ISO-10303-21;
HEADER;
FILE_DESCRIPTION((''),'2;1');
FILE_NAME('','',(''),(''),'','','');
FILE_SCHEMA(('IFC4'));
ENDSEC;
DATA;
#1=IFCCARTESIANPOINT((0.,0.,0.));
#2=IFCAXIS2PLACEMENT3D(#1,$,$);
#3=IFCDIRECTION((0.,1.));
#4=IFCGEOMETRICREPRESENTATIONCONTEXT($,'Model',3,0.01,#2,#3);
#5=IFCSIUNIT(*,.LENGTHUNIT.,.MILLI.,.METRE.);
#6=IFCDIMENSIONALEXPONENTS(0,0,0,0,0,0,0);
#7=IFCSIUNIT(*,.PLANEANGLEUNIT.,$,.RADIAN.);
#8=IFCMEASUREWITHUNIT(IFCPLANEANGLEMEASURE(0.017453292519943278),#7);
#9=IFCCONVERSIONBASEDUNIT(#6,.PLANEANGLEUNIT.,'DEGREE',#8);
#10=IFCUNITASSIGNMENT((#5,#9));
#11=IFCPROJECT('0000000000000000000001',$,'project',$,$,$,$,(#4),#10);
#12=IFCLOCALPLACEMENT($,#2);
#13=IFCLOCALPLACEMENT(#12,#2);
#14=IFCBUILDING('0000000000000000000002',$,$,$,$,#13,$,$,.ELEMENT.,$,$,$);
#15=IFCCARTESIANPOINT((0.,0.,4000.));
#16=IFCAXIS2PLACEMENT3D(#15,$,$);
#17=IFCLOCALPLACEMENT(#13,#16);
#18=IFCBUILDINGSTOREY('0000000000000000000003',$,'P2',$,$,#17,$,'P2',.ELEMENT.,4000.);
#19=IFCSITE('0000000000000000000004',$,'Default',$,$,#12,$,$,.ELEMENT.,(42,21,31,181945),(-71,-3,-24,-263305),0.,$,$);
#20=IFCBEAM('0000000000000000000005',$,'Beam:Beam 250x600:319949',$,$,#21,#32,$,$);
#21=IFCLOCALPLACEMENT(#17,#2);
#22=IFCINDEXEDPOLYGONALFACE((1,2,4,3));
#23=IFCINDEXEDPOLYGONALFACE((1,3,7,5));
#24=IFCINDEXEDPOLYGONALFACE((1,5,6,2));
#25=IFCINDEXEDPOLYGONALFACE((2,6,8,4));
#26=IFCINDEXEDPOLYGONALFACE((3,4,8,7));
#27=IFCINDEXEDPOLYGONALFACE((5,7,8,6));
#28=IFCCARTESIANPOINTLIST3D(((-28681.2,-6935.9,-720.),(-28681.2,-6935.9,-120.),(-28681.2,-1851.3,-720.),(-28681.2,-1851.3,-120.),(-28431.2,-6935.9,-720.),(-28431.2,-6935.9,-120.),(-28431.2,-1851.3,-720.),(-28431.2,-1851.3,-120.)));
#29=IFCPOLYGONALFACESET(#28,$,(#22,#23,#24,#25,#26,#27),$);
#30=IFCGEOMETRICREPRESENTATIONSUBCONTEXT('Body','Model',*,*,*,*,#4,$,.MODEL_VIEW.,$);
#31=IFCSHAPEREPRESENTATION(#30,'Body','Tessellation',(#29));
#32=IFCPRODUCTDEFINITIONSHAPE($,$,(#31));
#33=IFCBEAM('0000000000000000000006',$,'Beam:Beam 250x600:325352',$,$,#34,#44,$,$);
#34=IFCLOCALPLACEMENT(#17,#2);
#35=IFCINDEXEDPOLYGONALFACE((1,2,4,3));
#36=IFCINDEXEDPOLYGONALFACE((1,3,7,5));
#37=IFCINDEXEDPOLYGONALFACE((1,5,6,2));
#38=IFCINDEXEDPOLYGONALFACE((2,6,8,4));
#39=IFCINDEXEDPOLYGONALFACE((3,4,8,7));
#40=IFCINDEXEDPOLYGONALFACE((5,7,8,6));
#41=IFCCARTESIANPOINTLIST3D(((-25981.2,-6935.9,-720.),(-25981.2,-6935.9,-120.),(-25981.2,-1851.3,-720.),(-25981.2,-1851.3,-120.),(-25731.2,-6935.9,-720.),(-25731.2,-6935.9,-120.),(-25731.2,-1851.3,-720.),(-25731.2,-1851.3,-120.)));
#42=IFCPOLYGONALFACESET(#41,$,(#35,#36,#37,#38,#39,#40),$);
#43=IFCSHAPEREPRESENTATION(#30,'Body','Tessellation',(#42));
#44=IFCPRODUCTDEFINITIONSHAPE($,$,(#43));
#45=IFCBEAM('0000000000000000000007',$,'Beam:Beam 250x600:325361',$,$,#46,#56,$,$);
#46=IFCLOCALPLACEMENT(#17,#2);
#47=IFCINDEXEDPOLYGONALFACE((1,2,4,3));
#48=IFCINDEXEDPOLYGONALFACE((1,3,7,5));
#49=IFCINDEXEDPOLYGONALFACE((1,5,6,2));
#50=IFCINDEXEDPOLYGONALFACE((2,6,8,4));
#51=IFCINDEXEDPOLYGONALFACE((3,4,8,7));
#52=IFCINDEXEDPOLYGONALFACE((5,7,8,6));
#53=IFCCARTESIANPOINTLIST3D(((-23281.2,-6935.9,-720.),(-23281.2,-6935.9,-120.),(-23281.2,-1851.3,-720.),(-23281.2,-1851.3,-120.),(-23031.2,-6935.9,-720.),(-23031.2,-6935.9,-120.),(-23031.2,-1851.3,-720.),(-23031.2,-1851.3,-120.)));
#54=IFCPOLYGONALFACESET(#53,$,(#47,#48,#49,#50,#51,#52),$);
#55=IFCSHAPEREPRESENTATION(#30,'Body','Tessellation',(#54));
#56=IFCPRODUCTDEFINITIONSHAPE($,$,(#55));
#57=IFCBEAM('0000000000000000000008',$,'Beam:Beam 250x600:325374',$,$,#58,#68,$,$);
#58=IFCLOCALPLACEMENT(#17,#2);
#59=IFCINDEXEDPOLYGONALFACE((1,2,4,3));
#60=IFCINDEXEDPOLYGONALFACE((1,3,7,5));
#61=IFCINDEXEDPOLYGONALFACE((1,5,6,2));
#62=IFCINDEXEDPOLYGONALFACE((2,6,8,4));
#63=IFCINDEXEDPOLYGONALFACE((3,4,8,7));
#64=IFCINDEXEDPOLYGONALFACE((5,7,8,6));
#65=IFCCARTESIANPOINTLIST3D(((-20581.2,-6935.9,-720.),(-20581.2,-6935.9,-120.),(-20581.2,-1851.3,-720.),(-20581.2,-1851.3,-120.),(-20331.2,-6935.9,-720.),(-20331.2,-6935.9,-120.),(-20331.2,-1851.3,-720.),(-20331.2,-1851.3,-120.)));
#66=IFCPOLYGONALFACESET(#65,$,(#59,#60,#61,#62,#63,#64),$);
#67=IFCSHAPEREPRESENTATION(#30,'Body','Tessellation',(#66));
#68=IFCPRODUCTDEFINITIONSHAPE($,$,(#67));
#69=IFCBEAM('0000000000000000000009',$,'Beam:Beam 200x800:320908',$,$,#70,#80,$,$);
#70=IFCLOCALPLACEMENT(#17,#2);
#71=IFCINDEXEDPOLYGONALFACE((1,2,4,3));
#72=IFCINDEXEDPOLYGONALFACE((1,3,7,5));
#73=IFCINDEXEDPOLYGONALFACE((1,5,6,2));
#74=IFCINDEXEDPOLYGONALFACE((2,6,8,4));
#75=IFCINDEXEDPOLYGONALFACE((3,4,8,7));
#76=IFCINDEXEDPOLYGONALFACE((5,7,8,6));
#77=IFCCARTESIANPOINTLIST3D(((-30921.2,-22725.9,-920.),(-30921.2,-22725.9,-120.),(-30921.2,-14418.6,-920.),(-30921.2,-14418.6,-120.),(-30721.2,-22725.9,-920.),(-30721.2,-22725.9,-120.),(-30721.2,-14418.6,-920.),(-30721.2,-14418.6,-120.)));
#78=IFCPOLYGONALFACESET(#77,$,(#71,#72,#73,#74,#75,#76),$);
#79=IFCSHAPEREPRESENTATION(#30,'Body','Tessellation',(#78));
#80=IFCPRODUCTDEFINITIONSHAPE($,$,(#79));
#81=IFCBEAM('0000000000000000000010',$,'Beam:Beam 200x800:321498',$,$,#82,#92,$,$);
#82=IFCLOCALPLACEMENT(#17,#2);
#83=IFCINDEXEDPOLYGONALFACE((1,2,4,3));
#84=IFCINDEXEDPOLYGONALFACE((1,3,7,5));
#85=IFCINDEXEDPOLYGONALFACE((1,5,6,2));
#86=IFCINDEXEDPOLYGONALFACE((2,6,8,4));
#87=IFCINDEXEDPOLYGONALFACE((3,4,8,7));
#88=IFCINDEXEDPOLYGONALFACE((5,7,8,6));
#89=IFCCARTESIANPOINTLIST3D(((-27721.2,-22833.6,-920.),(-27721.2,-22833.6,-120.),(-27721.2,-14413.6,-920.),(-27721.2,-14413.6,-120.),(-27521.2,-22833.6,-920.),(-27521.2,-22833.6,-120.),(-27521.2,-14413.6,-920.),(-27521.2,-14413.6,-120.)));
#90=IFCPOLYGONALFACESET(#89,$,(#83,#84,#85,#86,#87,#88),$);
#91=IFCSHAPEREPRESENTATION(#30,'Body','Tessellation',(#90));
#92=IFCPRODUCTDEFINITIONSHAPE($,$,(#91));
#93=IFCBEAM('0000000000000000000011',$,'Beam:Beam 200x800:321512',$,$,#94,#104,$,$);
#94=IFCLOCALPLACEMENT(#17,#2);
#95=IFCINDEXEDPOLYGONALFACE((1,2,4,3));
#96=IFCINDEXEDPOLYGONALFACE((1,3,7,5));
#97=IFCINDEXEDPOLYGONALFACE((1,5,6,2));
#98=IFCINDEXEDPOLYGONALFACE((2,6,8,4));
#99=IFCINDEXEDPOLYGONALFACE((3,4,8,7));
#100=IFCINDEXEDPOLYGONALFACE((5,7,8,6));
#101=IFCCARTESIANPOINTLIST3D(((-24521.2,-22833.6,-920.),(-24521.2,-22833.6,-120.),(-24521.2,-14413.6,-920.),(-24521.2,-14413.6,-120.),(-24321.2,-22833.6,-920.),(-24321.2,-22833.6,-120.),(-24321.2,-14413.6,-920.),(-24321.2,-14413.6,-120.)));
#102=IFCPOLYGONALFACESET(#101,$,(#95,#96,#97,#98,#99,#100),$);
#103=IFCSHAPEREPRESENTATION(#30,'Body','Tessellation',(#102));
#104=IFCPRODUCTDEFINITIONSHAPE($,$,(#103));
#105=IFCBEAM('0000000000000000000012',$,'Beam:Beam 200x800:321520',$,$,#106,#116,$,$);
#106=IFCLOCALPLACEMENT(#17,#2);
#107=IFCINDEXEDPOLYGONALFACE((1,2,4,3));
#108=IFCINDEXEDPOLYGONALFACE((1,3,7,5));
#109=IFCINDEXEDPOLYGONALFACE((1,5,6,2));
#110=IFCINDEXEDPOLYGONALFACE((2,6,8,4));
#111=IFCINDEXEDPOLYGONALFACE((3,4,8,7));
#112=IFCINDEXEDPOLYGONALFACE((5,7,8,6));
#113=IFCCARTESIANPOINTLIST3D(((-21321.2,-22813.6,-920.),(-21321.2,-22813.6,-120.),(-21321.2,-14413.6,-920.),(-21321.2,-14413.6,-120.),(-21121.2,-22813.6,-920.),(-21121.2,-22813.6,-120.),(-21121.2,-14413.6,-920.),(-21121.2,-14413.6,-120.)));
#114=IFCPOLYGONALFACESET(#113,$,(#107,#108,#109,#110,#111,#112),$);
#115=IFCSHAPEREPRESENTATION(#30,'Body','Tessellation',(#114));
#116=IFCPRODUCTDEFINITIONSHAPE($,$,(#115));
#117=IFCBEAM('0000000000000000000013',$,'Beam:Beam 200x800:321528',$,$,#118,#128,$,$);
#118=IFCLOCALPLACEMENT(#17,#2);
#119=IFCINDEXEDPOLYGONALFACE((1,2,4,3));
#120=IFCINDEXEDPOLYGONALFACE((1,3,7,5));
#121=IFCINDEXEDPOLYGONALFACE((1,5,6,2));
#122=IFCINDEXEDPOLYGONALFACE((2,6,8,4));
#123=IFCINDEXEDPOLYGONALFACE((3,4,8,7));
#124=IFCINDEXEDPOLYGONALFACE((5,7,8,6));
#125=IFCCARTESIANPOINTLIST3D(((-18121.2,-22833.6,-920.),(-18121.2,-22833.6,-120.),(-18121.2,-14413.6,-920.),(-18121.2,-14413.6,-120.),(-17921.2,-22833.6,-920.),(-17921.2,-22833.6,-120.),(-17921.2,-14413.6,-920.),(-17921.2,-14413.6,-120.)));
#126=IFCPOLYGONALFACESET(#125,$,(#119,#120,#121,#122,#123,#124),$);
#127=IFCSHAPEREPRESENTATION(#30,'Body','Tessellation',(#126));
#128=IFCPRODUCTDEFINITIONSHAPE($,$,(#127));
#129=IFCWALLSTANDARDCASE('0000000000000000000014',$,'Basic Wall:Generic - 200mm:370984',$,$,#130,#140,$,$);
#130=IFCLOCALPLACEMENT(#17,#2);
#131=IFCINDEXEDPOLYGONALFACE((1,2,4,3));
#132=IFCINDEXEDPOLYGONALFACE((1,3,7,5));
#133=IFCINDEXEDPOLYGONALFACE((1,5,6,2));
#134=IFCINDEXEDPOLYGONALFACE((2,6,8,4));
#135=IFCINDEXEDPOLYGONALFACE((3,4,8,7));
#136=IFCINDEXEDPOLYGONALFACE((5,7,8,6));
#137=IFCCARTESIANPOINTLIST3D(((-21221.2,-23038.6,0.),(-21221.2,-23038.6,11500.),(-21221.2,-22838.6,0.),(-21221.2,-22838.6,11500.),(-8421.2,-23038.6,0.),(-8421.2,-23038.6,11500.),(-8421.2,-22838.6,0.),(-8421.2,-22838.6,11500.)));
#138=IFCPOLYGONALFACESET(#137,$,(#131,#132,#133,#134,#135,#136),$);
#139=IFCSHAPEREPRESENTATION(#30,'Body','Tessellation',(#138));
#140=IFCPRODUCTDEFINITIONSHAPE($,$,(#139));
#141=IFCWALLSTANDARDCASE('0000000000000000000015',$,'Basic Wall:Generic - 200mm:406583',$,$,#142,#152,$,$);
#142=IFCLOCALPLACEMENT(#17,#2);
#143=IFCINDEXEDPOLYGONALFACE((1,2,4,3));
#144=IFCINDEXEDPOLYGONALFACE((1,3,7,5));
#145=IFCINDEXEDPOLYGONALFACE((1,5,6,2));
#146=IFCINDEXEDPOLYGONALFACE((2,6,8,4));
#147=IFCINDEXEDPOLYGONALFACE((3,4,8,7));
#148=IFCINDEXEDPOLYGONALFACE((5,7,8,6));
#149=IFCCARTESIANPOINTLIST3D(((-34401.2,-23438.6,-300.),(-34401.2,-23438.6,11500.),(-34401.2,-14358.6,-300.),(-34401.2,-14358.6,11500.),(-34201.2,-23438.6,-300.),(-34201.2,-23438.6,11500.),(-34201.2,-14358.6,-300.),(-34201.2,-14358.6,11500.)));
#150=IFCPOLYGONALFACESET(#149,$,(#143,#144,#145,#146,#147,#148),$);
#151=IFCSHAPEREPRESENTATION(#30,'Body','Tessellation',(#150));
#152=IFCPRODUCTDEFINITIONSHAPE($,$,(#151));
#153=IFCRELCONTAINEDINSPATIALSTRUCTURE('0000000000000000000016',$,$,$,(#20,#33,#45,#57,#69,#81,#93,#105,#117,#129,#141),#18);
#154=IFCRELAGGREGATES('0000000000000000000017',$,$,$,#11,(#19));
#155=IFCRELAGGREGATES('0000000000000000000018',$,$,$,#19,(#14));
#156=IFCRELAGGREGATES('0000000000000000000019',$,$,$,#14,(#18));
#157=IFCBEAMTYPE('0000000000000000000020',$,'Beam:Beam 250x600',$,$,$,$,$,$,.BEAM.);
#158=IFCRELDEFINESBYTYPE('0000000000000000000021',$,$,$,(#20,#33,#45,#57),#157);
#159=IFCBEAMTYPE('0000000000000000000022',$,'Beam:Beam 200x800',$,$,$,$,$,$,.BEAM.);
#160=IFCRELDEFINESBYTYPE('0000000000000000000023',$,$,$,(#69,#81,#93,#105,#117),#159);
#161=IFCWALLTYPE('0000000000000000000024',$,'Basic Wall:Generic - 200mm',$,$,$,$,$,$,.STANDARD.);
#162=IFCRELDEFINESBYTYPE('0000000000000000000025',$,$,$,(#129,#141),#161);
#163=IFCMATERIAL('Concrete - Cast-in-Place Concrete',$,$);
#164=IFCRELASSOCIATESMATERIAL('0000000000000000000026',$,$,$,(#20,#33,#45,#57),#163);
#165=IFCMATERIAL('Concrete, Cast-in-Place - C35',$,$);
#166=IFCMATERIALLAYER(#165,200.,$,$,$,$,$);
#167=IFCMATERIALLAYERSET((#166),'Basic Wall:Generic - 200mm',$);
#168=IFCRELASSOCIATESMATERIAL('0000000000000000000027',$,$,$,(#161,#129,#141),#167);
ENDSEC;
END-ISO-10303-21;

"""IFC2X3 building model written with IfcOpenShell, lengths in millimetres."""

from ifc_helpers import new_model, entity, si_unit, converted_unit, direction, frame, frame_2d, origin, place, context, subcontext, project, spatial, rectangle, extrude, material, layer, layer_set, layer_usage, type_object, element, save


model = new_model("IFC2X3")

# Units and contexts
model_context = context("Model", 3, precision=0.01, world=origin(), true_north=direction((0.0, 1.0)))
body_context = subcontext(model_context, "Body", "Model", "MODEL_VIEW")
ifc_project = project(units=[si_unit("LENGTHUNIT", "METRE", prefix="MILLI"), converted_unit("PLANEANGLEUNIT", "DEGREE", entity("IfcPlaneAngleMeasure", 0.017453292519943278), si_unit("PLANEANGLEUNIT", "RADIAN"), dimensions=[0, 0, 0, 0, 0, 0, 0])], contexts=[model_context])

# Site, building, storey
site_placement = place(None, origin())
site = spatial("IfcSite", under=ifc_project, at=site_placement, Name="Default", CompositionType="ELEMENT", RefLatitude=(42, 21, 31, 181945), RefLongitude=(-71, -3, -24, -263305), RefElevation=0.0)
building_placement = place(site_placement, origin())
building = spatial("IfcBuilding", under=site, at=building_placement, CompositionType="ELEMENT")
storey_placement = place(building_placement, frame((0.0, 0.0, 4000.0)))
storey = spatial("IfcBuildingStorey", under=building, at=storey_placement, Name="P2", LongName="P2", CompositionType="ELEMENT", Elevation=4000.0)

# Shared definitions
ifc_material_1 = material(Name="Concrete, Cast-in-Place - C35")

# Beams
ifc_material_2 = material(Name="Concrete - Cast-in-Place Concrete")
beam_type_1 = type_object("IfcBeamType", Name="Beam:Beam 250x600", PredefinedType="BEAM")
for number, where, z_axis, x_axis, name in (
    (1, (-28556.2, -6978.6, -120.0), (0.0, 0.0, 1.0), (0.0, 1.0, 0.0), "Beam:Beam 250x600:319949"),
    (2, (-25856.2, -6978.6, -120.0), (0.0, 0.0, 1.0), (0.0, 1.0, 0.0), "Beam:Beam 250x600:325352"),
):
    element("IfcBeam", number, at=place(storey_placement, frame(where, z_axis=z_axis, x_axis=x_axis)), inside=storey, type_object=beam_type_1, material=ifc_material_2, Name=name, context=body_context, shape_type="SweptSolid", body=[
        extrude(rectangle(XDim=600.0, YDim=250.0, at=frame_2d((0.0, 0.0), x_axis=(1.0, 0.0))), frame((42.7, 0.0, -300.0), z_axis=(1.0, 0.0, 0.0), x_axis=(0.0, 0.0, -1.0)), (0.0, 0.0, 1.0), 5084.6),
    ])
for number, where, z_axis, x_axis, name in (
    (3, (-23156.2, -6978.6, -120.0), (0.0, 0.0, 1.0), (0.0, 1.0, 0.0), "Beam:Beam 250x600:325361"),
    (4, (-20456.2, -6978.6, -120.0), (0.0, 0.0, 1.0), (0.0, 1.0, 0.0), "Beam:Beam 250x600:325374"),
):
    element("IfcBeam", number, at=place(storey_placement, frame(where, z_axis=z_axis, x_axis=x_axis)), inside=storey, type_object=beam_type_1, material=ifc_material_2, Name=name, context=body_context, shape_type="SweptSolid", body=[
        extrude(rectangle(XDim=600.0, YDim=250.0, at=frame_2d((0.0, 0.0), x_axis=(1.0, 0.0))), frame((42.7, 0.0, -300.0), z_axis=(1.0, 0.0, 0.0), x_axis=(0.0, 0.0, -1.0)), (0.0, 0.0, 1.0), 5084.6),
    ])
beam_type_2 = type_object("IfcBeamType", Name="Beam:Beam 200x800", PredefinedType="BEAM")
beam_1_placement = place(storey_placement, frame((-30846.2, -14418.6, -120.0), z_axis=(0.0, 0.0, 1.0), x_axis=(0.0, -1.0, 0.0)))
element("IfcBeam", 5, at=beam_1_placement, inside=storey, type_object=beam_type_2, Name="Beam:Beam 200x800:320908", context=body_context, shape_type="SweptSolid", body=[
    extrude(rectangle(XDim=800.0, YDim=200.0, at=frame_2d((0.0, 0.0), x_axis=(1.0, 0.0))), frame((0.0, 25.0, -400.0), z_axis=(1.0, 0.0, 0.0), x_axis=(0.0, 0.0, -1.0)), (0.0, 0.0, 1.0), 8307.3),
])
beam_2_placement = place(storey_placement, frame((-27646.2, -14413.6, -120.0), z_axis=(0.0, 0.0, 1.0), x_axis=(0.0, -1.0, 0.0)))
element("IfcBeam", 6, at=beam_2_placement, inside=storey, type_object=beam_type_2, Name="Beam:Beam 200x800:321498", context=body_context, shape_type="SweptSolid", body=[
    extrude(rectangle(XDim=800.0, YDim=200.0, at=frame_2d((0.0, 0.0), x_axis=(1.0, 0.0))), frame((0.0, 25.0, -400.0), z_axis=(1.0, 0.0, 0.0), x_axis=(0.0, 0.0, -1.0)), (0.0, 0.0, 1.0), 8420.0),
])
beam_3_placement = place(storey_placement, frame((-24446.2, -14413.6, -120.0), z_axis=(0.0, 0.0, 1.0), x_axis=(0.0, -1.0, 0.0)))
element("IfcBeam", 7, at=beam_3_placement, inside=storey, type_object=beam_type_2, Name="Beam:Beam 200x800:321512", context=body_context, shape_type="SweptSolid", body=[
    extrude(rectangle(XDim=800.0, YDim=200.0, at=frame_2d((0.0, 0.0), x_axis=(1.0, 0.0))), frame((0.0, 25.0, -400.0), z_axis=(1.0, 0.0, 0.0), x_axis=(0.0, 0.0, -1.0)), (0.0, 0.0, 1.0), 8420.0),
])
beam_4_placement = place(storey_placement, frame((-21246.2, -14413.6, -120.0), z_axis=(0.0, 0.0, 1.0), x_axis=(0.0, -1.0, 0.0)))
element("IfcBeam", 8, at=beam_4_placement, inside=storey, type_object=beam_type_2, Name="Beam:Beam 200x800:321520", context=body_context, shape_type="SweptSolid", body=[
    extrude(rectangle(XDim=800.0, YDim=200.0, at=frame_2d((0.0, 0.0), x_axis=(1.0, 0.0))), frame((0.0, 25.0, -400.0), z_axis=(1.0, 0.0, 0.0), x_axis=(0.0, 0.0, -1.0)), (0.0, 0.0, 1.0), 8400.0),
])
beam_5_placement = place(storey_placement, frame((-18046.2, -14413.6, -120.0), z_axis=(0.0, 0.0, 1.0), x_axis=(0.0, -1.0, 0.0)))
element("IfcBeam", 9, at=beam_5_placement, inside=storey, type_object=beam_type_2, Name="Beam:Beam 200x800:321528", context=body_context, shape_type="SweptSolid", body=[
    extrude(rectangle(XDim=800.0, YDim=200.0, at=frame_2d((0.0, 0.0), x_axis=(1.0, 0.0))), frame((0.0, 25.0, -400.0), z_axis=(1.0, 0.0, 0.0), x_axis=(0.0, 0.0, -1.0)), (0.0, 0.0, 1.0), 8420.0),
])

# Walls
ifc_layer = layer(ifc_material_1, 200.0)
ifc_layer_set = layer_set([ifc_layer], Name="Basic Wall:Generic - 200mm")
ifc_layer_usage_1 = layer_usage(ifc_layer_set, "AXIS2", "NEGATIVE", 100.0)
wall_type = type_object("IfcWallType", Name="Basic Wall:Generic - 200mm", PredefinedType="STANDARD", material=ifc_layer_set)
wall_1_placement = place(storey_placement, frame((-21221.2, -22938.6, 0.0)))
element("IfcWallStandardCase", 10, at=wall_1_placement, inside=storey, type_object=wall_type, material=ifc_layer_usage_1, Name="Basic Wall:Generic - 200mm:370984", context=body_context, shape_type="SweptSolid", body=[
    extrude(rectangle(XDim=12800.0, YDim=200.0, at=frame_2d((6400.0, 0.0), x_axis=(-1.0, 0.0))), origin(), (0.0, 0.0, 1.0), 11500.0),
])
ifc_layer_usage_2 = layer_usage(ifc_layer_set, "AXIS2", "NEGATIVE", 100.0)
wall_2_placement = place(storey_placement, frame((-34301.2, -14358.6, -300.0), z_axis=(0.0, 0.0, 1.0), x_axis=(0.0, -1.0, 0.0)))
element("IfcWallStandardCase", 11, at=wall_2_placement, inside=storey, type_object=wall_type, material=ifc_layer_usage_2, Name="Basic Wall:Generic - 200mm:406583", context=body_context, shape_type="SweptSolid", body=[
    extrude(rectangle(XDim=9080.0, YDim=200.0, at=frame_2d((4540.0, 0.0), x_axis=(-1.0, 0.0))), origin(), (0.0, 0.0, 1.0), 11800.0),
])

save(model, "model.ifc")
